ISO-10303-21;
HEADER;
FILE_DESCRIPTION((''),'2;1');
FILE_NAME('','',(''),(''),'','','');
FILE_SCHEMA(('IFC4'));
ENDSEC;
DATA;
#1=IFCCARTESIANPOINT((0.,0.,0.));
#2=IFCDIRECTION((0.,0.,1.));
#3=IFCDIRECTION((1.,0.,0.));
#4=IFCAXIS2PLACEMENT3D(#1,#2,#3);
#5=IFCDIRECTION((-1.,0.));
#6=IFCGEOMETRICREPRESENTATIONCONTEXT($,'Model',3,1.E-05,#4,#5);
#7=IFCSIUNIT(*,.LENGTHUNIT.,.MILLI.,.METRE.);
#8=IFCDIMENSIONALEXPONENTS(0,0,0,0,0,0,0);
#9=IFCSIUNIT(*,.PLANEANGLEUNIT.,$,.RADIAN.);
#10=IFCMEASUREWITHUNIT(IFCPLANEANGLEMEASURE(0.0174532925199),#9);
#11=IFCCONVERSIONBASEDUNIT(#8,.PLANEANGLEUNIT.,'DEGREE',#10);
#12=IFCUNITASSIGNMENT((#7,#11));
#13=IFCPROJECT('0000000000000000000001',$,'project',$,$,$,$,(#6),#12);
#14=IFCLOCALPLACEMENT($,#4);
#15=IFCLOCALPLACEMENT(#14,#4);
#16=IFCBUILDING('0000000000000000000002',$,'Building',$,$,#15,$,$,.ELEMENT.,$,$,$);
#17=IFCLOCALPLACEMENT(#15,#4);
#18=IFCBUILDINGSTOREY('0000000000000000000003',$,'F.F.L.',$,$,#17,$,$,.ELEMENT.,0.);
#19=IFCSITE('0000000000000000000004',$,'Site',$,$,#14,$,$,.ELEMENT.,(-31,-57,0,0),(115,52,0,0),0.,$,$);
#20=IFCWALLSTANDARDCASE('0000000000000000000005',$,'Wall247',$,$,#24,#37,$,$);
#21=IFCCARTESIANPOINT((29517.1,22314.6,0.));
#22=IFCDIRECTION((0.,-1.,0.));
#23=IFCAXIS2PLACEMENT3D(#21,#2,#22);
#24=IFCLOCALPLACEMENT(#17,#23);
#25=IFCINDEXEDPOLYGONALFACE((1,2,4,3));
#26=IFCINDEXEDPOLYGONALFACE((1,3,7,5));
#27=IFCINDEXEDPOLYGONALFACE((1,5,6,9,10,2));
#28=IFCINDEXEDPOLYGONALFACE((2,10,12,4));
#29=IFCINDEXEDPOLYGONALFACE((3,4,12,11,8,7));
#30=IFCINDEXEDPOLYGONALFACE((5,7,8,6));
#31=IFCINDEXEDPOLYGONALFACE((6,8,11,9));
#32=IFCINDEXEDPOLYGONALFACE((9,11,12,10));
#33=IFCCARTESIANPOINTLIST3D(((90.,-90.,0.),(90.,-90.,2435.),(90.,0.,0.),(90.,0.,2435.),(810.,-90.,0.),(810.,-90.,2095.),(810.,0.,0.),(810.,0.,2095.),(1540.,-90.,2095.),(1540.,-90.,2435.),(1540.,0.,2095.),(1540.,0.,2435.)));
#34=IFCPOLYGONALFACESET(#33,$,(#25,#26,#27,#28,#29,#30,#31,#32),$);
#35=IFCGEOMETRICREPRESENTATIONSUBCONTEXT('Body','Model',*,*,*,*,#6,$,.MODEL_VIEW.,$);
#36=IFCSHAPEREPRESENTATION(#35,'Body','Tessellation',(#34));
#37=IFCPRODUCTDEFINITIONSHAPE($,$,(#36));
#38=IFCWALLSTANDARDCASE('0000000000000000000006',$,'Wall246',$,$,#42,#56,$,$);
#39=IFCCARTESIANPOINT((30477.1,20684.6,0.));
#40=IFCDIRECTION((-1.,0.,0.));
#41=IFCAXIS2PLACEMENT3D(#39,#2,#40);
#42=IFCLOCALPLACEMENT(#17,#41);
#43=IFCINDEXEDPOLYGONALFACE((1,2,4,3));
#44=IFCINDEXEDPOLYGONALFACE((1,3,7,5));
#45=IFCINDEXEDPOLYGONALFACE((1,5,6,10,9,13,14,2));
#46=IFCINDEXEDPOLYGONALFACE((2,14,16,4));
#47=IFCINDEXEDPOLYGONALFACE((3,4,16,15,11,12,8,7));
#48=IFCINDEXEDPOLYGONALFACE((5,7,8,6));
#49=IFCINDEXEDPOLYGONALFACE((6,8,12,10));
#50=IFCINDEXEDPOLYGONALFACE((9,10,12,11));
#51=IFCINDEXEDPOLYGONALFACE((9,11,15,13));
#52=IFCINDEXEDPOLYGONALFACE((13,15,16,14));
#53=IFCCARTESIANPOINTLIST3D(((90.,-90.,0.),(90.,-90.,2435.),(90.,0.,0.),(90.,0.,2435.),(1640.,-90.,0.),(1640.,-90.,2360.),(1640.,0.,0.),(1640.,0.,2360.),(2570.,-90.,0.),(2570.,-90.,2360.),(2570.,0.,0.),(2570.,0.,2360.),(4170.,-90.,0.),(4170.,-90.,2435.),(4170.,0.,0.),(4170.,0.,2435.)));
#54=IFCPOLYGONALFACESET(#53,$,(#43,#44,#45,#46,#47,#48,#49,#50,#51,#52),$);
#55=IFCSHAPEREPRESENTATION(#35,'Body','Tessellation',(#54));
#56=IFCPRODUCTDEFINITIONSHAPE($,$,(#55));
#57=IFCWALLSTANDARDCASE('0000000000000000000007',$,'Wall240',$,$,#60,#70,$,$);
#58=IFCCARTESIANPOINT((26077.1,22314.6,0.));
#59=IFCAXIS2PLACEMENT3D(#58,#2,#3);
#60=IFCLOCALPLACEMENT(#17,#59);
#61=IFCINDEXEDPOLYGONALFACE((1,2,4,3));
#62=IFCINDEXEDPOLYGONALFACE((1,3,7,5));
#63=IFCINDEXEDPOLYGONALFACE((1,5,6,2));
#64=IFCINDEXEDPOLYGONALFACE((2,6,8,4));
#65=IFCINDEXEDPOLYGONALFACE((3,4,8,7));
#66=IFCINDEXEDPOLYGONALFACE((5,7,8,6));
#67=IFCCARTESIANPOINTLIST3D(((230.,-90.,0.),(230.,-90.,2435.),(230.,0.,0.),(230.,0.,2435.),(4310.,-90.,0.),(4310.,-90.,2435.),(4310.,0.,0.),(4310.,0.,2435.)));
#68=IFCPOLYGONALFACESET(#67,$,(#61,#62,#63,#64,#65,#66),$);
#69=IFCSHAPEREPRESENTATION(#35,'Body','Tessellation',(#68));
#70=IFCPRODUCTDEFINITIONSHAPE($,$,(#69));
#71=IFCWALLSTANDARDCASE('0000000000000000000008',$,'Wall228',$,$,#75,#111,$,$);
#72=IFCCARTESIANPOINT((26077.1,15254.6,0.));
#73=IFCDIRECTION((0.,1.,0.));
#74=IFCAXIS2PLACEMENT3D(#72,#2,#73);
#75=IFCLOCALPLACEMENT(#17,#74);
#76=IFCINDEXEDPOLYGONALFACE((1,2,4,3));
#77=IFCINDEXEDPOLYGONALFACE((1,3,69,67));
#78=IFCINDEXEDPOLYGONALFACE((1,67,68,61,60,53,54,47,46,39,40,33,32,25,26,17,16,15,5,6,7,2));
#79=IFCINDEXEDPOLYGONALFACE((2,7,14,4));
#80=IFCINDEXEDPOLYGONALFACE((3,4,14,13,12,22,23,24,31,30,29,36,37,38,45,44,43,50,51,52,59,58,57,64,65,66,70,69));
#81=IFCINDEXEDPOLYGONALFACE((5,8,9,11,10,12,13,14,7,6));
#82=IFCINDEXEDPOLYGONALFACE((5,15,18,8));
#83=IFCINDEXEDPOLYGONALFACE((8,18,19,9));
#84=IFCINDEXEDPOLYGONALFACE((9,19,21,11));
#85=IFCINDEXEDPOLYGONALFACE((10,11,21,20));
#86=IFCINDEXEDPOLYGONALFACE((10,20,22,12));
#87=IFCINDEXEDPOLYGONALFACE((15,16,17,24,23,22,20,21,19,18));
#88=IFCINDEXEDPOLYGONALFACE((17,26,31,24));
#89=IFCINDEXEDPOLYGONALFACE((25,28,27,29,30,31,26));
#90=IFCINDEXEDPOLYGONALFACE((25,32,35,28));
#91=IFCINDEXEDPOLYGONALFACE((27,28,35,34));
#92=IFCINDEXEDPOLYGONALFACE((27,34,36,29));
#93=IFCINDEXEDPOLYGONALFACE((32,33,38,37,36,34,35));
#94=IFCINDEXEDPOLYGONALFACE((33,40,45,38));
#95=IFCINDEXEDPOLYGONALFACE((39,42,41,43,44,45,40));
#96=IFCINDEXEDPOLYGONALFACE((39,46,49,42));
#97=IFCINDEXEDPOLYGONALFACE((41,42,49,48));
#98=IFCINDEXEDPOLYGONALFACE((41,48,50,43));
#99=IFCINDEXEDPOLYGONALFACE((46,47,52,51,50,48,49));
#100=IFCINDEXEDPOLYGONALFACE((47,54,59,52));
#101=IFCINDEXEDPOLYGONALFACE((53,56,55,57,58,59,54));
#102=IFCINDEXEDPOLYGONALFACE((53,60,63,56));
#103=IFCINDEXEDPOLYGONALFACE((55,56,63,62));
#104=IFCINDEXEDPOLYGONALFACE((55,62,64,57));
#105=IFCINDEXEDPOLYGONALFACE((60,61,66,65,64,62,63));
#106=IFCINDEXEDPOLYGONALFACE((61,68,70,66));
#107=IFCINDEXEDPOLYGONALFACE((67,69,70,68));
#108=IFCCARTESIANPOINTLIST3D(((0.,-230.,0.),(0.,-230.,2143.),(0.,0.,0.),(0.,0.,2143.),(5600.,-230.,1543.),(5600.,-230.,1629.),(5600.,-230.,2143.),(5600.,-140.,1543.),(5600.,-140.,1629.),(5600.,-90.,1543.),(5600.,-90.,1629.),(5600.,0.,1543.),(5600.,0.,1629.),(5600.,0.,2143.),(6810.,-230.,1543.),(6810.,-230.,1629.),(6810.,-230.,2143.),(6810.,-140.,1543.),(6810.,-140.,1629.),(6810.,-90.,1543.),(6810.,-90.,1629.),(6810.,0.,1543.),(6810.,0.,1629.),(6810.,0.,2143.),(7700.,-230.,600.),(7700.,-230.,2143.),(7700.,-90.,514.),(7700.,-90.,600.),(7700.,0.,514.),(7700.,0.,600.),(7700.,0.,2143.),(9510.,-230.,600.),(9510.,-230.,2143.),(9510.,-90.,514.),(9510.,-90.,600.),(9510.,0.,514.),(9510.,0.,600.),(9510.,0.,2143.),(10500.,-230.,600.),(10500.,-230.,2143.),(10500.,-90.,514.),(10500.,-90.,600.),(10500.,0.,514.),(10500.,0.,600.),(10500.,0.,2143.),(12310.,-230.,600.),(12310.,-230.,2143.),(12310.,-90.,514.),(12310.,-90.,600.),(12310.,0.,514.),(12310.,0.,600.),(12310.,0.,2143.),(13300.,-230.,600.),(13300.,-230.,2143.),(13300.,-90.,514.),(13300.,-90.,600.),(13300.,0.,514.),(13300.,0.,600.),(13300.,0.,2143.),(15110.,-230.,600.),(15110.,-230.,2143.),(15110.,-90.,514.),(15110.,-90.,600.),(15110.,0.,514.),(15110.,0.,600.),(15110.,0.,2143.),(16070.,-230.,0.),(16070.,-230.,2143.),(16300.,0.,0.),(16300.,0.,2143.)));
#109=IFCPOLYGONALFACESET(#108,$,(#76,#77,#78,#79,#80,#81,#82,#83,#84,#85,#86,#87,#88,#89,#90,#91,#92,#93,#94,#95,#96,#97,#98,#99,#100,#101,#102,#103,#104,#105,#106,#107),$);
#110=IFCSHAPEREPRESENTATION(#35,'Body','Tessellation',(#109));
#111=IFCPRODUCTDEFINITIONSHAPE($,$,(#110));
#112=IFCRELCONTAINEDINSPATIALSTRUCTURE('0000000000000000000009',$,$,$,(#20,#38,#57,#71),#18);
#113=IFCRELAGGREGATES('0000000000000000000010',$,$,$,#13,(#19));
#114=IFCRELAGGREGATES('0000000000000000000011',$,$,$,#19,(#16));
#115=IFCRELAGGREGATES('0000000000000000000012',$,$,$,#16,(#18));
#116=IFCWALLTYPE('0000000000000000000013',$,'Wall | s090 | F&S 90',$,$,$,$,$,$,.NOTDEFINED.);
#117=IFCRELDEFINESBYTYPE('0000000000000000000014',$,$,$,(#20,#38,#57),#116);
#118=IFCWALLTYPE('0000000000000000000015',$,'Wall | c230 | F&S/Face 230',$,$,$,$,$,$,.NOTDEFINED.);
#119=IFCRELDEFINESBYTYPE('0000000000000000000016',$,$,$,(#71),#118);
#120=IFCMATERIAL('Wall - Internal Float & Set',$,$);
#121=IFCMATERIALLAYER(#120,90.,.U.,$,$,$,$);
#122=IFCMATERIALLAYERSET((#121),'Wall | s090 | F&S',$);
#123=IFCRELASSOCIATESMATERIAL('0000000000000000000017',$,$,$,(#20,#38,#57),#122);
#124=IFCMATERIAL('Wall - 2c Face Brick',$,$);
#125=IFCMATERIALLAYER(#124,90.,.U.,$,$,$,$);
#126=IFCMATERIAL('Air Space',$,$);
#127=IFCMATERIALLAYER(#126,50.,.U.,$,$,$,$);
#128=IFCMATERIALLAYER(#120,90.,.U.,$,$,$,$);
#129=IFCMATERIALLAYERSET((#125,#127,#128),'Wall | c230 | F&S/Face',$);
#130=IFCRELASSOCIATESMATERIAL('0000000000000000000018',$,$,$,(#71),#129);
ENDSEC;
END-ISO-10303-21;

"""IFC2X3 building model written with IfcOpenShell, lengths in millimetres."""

from ifc_helpers import new_model, entity, si_unit, converted_unit, direction, frame, origin_with_axes, origin_2d_with_axis, place, context, subcontext, project, spatial, polyline, rectangle, outline, extrude, material, layer, layer_set, layer_usage, type_object, element, save


model = new_model("IFC2X3")

# Units and contexts
model_context = context("Model", 3, precision=1e-05, world=origin_with_axes(), true_north=direction((-1.0, 0.0)))
body_context = subcontext(model_context, "Body", "Model", "MODEL_VIEW")
ifc_project = project(units=[si_unit("LENGTHUNIT", "METRE", prefix="MILLI"), converted_unit("PLANEANGLEUNIT", "DEGREE", entity("IfcPlaneAngleMeasure", 0.0174532925199), si_unit("PLANEANGLEUNIT", "RADIAN"), dimensions=[0, 0, 0, 0, 0, 0, 0])], contexts=[model_context])

# Site, building, storey
site_placement = place(None, origin_with_axes())
site = spatial("IfcSite", under=ifc_project, at=site_placement, Name="Site", CompositionType="ELEMENT", RefLatitude=(-31, -57, 0, 0), RefLongitude=(115, 52, 0, 0), RefElevation=0.0)
building_placement = place(site_placement, origin_with_axes())
building = spatial("IfcBuilding", under=site, at=building_placement, Name="Building", CompositionType="ELEMENT")
storey_placement = place(building_placement, origin_with_axes())
storey = spatial("IfcBuildingStorey", under=building, at=storey_placement, Name="F.F.L.", CompositionType="ELEMENT", Elevation=0.0)

# Shared definitions
ifc_material_1 = material(Name="Wall - Internal Float & Set")
ifc_layer_1 = layer(ifc_material_1, 90.0, ventilated="UNKNOWN")
ifc_layer_set_1 = layer_set([ifc_layer_1], Name="Wall | s090 | F&S")
wall_type_1 = type_object("IfcWallType", Name="Wall | s090 | F&S 90", PredefinedType="NOTDEFINED")

# Walls, openings
ifc_layer_usage_1 = layer_usage(ifc_layer_set_1, "AXIS2", "POSITIVE", -90.0)
wall_1_placement = place(storey_placement, frame((29517.1, 22314.6, 0.0), z_axis=(0.0, 0.0, 1.0), x_axis=(0.0, -1.0, 0.0)))
wall_1 = element("IfcWallStandardCase", 1, at=wall_1_placement, inside=storey, type_object=wall_type_1, material=ifc_layer_usage_1, Name="Wall247", context=body_context, shape_type="SweptSolid", body=[
    extrude(outline(polyline([(90.0, -90.0), (1540.0, -90.0), (1540.0, 0.0), (90.0, 0.0), (90.0, -90.0)])), origin_with_axes(), (0.0, 0.0, 1.0), 2435.0),
])
opening_1_placement = place(wall_1_placement, frame((1175.0, 0.0, 0.0), z_axis=(0.0, 0.0, 1.0), x_axis=(1.0, 0.0, 0.0)))
element("IfcOpeningElement", 2, at=opening_1_placement, cuts=wall_1, context=body_context, shape_type="SweptSolid", body=[
    extrude(rectangle(XDim=730.0, YDim=2095.0, at=origin_2d_with_axis()), frame((0.0, -90.0, 1047.5), z_axis=(0.0, 1.0, 0.0), x_axis=(1.0, 0.0, 0.0)), (0.0, 0.0, 1.0), 180.0),
])
ifc_layer_usage_2 = layer_usage(ifc_layer_set_1, "AXIS2", "POSITIVE", -90.0)
wall_2_placement = place(storey_placement, frame((30477.1, 20684.6, 0.0), z_axis=(0.0, 0.0, 1.0), x_axis=(-1.0, 0.0, 0.0)))
wall_2 = element("IfcWallStandardCase", 3, at=wall_2_placement, inside=storey, type_object=wall_type_1, material=ifc_layer_usage_2, Name="Wall246", context=body_context, shape_type="SweptSolid", body=[
    extrude(outline(polyline([(90.0, -90.0), (4170.0, -90.0), (4170.0, 0.0), (90.0, 0.0), (90.0, -90.0)])), origin_with_axes(), (0.0, 0.0, 1.0), 2435.0),
])
opening_2_placement = place(wall_2_placement, frame((2105.0, 0.0, 0.0), z_axis=(0.0, 0.0, 1.0), x_axis=(1.0, 0.0, 0.0)))
element("IfcOpeningElement", 4, at=opening_2_placement, cuts=wall_2, context=body_context, shape_type="SweptSolid", body=[
    extrude(rectangle(XDim=930.0, YDim=2360.0, at=origin_2d_with_axis()), frame((0.0, -90.0, 1180.0), z_axis=(0.0, 1.0, 0.0), x_axis=(1.0, 0.0, 0.0)), (0.0, 0.0, 1.0), 180.0),
])

# Wall
ifc_layer_usage_3 = layer_usage(ifc_layer_set_1, "AXIS2", "POSITIVE", -90.0)
wall_3_placement = place(storey_placement, frame((26077.1, 22314.6, 0.0), z_axis=(0.0, 0.0, 1.0), x_axis=(1.0, 0.0, 0.0)))
element("IfcWallStandardCase", 5, at=wall_3_placement, inside=storey, type_object=wall_type_1, material=ifc_layer_usage_3, Name="Wall240", context=body_context, shape_type="SweptSolid", body=[
    extrude(outline(polyline([(230.0, -90.0), (4310.0, -90.0), (4310.0, 0.0), (230.0, 0.0), (230.0, -90.0)])), origin_with_axes(), (0.0, 0.0, 1.0), 2435.0),
])

# Shared definitions
ifc_material_2 = material(Name="Wall - 2c Face Brick")

# Shared definitions
ifc_material_3 = material(Name="Air Space")

# Wall, openings
ifc_layer_2 = layer(ifc_material_2, 90.0, ventilated="UNKNOWN")
ifc_layer_3 = layer(ifc_material_3, 50.0, ventilated="UNKNOWN")
ifc_layer_4 = layer(ifc_material_1, 90.0, ventilated="UNKNOWN")
ifc_layer_set_2 = layer_set([ifc_layer_2, ifc_layer_3, ifc_layer_4], Name="Wall | c230 | F&S/Face")
ifc_layer_usage_4 = layer_usage(ifc_layer_set_2, "AXIS2", "NEGATIVE", 0.0)
wall_type_2 = type_object("IfcWallType", Name="Wall | c230 | F&S/Face 230", PredefinedType="NOTDEFINED")
wall_4_placement = place(storey_placement, frame((26077.1, 15254.6, 0.0), z_axis=(0.0, 0.0, 1.0), x_axis=(0.0, 1.0, 0.0)))
wall_4 = element("IfcWallStandardCase", 6, at=wall_4_placement, inside=storey, type_object=wall_type_2, material=ifc_layer_usage_4, Name="Wall228", context=body_context, shape_type="SweptSolid", body=[
    extrude(outline(polyline([(0.0, -230.0), (16070.0, -230.0), (16300.0, 0.0), (0.0, 0.0), (0.0, -230.0)])), origin_with_axes(), (0.0, 0.0, 1.0), 2143.0),
])
opening_3_placement = place(wall_4_placement, frame((14205.0, 0.0, 600.0), z_axis=(0.0, 0.0, 1.0), x_axis=(1.0, 0.0, 0.0)))
element("IfcOpeningElement", 7, at=opening_3_placement, cuts=wall_4, context=body_context, shape_type="SweptSolid", body=[
    extrude(rectangle(XDim=1810.0, YDim=1543.0, at=origin_2d_with_axis()), frame((0.0, 15070.0, 771.5), z_axis=(0.0, 1.0, 0.0), x_axis=(1.0, 0.0, 0.0)), (0.0, 0.0, -1.0), 15380.0),
    extrude(outline(polyline([(-905.0, -86.0), (905.0, -86.0), (905.0, 0.0), (-905.0, 0.0), (-905.0, -86.0)])), frame((0.0, 2050.0, 0.0), z_axis=(0.0, -1.0, 0.0), x_axis=(1.0, 0.0, 0.0)), (0.0, 0.0, 1.0), 2140.0),
    extrude(rectangle(XDim=1810.0, YDim=1543.0, at=origin_2d_with_axis()), frame((0.0, -80.0, 771.5), z_axis=(0.0, -1.0, 0.0), x_axis=(1.0, 0.0, 0.0)), (0.0, 0.0, -1.0), 310.0),
])
opening_4_placement = place(wall_4_placement, frame((11405.0, 0.0, 600.0), z_axis=(0.0, 0.0, 1.0), x_axis=(1.0, 0.0, 0.0)))
element("IfcOpeningElement", 8, at=opening_4_placement, cuts=wall_4, context=body_context, shape_type="SweptSolid", body=[
    extrude(rectangle(XDim=1810.0, YDim=1543.0, at=origin_2d_with_axis()), frame((0.0, 15070.0, 771.5), z_axis=(0.0, 1.0, 0.0), x_axis=(1.0, 0.0, 0.0)), (0.0, 0.0, -1.0), 15380.0),
    extrude(outline(polyline([(-905.0, -86.0), (905.0, -86.0), (905.0, 0.0), (-905.0, 0.0), (-905.0, -86.0)])), frame((0.0, 2050.0, 0.0), z_axis=(0.0, -1.0, 0.0), x_axis=(1.0, 0.0, 0.0)), (0.0, 0.0, 1.0), 2140.0),
    extrude(rectangle(XDim=1810.0, YDim=1543.0, at=origin_2d_with_axis()), frame((0.0, -80.0, 771.5), z_axis=(0.0, -1.0, 0.0), x_axis=(1.0, 0.0, 0.0)), (0.0, 0.0, -1.0), 310.0),
])
opening_5_placement = place(wall_4_placement, frame((8605.0, 0.0, 600.0), z_axis=(0.0, 0.0, 1.0), x_axis=(1.0, 0.0, 0.0)))
element("IfcOpeningElement", 9, at=opening_5_placement, cuts=wall_4, context=body_context, shape_type="SweptSolid", body=[
    extrude(rectangle(XDim=1810.0, YDim=1543.0, at=origin_2d_with_axis()), frame((0.0, 15070.0, 771.5), z_axis=(0.0, -1.0, 0.0), x_axis=(-1.0, 0.0, 0.0)), (0.0, 0.0, 1.0), 15380.0),
    extrude(outline(polyline([(-905.0, -86.0), (905.0, -86.0), (905.0, 0.0), (-905.0, 0.0), (-905.0, -86.0)])), frame((0.0, 2050.0, 0.0), z_axis=(0.0, 1.0, 0.0), x_axis=(-1.0, 0.0, 0.0)), (0.0, 0.0, -1.0), 2140.0),
    extrude(rectangle(XDim=1810.0, YDim=1543.0, at=origin_2d_with_axis()), frame((0.0, -80.0, 771.5), z_axis=(0.0, 1.0, 0.0), x_axis=(-1.0, 0.0, 0.0)), (0.0, 0.0, 1.0), 310.0),
])
opening_6_placement = place(wall_4_placement, frame((6205.0, 0.0, 1629.0), z_axis=(0.0, 0.0, 1.0), x_axis=(1.0, 0.0, 0.0)))
element("IfcOpeningElement", 10, at=opening_6_placement, cuts=wall_4, context=body_context, shape_type="SweptSolid", body=[
    extrude(rectangle(XDim=1210.0, YDim=514.0, at=origin_2d_with_axis()), frame((0.0, 15070.0, 257.0), z_axis=(0.0, -1.0, 0.0), x_axis=(-1.0, 0.0, 0.0)), (0.0, 0.0, 1.0), 15380.0),
    extrude(outline(polyline([(-605.0, -86.0), (605.0, -86.0), (605.0, 0.0), (-605.0, 0.0), (-605.0, -86.0)])), frame((0.0, 2050.0, 0.0), z_axis=(0.0, 1.0, 0.0), x_axis=(-1.0, 0.0, 0.0)), (0.0, 0.0, -1.0), 2140.0),
    extrude(outline(polyline([(-605.0, -86.0), (605.0, -86.0), (605.0, 0.0), (-605.0, 0.0), (-605.0, -86.0)])), frame((0.0, -140.0, 0.0), z_axis=(0.0, 1.0, 0.0), x_axis=(-1.0, 0.0, 0.0)), (0.0, 0.0, -1.0), 90.0),
    extrude(rectangle(XDim=1210.0, YDim=514.0, at=origin_2d_with_axis()), frame((0.0, -80.0, 257.0), z_axis=(0.0, 1.0, 0.0), x_axis=(-1.0, 0.0, 0.0)), (0.0, 0.0, 1.0), 310.0),
])

save(model, "model.ifc")
